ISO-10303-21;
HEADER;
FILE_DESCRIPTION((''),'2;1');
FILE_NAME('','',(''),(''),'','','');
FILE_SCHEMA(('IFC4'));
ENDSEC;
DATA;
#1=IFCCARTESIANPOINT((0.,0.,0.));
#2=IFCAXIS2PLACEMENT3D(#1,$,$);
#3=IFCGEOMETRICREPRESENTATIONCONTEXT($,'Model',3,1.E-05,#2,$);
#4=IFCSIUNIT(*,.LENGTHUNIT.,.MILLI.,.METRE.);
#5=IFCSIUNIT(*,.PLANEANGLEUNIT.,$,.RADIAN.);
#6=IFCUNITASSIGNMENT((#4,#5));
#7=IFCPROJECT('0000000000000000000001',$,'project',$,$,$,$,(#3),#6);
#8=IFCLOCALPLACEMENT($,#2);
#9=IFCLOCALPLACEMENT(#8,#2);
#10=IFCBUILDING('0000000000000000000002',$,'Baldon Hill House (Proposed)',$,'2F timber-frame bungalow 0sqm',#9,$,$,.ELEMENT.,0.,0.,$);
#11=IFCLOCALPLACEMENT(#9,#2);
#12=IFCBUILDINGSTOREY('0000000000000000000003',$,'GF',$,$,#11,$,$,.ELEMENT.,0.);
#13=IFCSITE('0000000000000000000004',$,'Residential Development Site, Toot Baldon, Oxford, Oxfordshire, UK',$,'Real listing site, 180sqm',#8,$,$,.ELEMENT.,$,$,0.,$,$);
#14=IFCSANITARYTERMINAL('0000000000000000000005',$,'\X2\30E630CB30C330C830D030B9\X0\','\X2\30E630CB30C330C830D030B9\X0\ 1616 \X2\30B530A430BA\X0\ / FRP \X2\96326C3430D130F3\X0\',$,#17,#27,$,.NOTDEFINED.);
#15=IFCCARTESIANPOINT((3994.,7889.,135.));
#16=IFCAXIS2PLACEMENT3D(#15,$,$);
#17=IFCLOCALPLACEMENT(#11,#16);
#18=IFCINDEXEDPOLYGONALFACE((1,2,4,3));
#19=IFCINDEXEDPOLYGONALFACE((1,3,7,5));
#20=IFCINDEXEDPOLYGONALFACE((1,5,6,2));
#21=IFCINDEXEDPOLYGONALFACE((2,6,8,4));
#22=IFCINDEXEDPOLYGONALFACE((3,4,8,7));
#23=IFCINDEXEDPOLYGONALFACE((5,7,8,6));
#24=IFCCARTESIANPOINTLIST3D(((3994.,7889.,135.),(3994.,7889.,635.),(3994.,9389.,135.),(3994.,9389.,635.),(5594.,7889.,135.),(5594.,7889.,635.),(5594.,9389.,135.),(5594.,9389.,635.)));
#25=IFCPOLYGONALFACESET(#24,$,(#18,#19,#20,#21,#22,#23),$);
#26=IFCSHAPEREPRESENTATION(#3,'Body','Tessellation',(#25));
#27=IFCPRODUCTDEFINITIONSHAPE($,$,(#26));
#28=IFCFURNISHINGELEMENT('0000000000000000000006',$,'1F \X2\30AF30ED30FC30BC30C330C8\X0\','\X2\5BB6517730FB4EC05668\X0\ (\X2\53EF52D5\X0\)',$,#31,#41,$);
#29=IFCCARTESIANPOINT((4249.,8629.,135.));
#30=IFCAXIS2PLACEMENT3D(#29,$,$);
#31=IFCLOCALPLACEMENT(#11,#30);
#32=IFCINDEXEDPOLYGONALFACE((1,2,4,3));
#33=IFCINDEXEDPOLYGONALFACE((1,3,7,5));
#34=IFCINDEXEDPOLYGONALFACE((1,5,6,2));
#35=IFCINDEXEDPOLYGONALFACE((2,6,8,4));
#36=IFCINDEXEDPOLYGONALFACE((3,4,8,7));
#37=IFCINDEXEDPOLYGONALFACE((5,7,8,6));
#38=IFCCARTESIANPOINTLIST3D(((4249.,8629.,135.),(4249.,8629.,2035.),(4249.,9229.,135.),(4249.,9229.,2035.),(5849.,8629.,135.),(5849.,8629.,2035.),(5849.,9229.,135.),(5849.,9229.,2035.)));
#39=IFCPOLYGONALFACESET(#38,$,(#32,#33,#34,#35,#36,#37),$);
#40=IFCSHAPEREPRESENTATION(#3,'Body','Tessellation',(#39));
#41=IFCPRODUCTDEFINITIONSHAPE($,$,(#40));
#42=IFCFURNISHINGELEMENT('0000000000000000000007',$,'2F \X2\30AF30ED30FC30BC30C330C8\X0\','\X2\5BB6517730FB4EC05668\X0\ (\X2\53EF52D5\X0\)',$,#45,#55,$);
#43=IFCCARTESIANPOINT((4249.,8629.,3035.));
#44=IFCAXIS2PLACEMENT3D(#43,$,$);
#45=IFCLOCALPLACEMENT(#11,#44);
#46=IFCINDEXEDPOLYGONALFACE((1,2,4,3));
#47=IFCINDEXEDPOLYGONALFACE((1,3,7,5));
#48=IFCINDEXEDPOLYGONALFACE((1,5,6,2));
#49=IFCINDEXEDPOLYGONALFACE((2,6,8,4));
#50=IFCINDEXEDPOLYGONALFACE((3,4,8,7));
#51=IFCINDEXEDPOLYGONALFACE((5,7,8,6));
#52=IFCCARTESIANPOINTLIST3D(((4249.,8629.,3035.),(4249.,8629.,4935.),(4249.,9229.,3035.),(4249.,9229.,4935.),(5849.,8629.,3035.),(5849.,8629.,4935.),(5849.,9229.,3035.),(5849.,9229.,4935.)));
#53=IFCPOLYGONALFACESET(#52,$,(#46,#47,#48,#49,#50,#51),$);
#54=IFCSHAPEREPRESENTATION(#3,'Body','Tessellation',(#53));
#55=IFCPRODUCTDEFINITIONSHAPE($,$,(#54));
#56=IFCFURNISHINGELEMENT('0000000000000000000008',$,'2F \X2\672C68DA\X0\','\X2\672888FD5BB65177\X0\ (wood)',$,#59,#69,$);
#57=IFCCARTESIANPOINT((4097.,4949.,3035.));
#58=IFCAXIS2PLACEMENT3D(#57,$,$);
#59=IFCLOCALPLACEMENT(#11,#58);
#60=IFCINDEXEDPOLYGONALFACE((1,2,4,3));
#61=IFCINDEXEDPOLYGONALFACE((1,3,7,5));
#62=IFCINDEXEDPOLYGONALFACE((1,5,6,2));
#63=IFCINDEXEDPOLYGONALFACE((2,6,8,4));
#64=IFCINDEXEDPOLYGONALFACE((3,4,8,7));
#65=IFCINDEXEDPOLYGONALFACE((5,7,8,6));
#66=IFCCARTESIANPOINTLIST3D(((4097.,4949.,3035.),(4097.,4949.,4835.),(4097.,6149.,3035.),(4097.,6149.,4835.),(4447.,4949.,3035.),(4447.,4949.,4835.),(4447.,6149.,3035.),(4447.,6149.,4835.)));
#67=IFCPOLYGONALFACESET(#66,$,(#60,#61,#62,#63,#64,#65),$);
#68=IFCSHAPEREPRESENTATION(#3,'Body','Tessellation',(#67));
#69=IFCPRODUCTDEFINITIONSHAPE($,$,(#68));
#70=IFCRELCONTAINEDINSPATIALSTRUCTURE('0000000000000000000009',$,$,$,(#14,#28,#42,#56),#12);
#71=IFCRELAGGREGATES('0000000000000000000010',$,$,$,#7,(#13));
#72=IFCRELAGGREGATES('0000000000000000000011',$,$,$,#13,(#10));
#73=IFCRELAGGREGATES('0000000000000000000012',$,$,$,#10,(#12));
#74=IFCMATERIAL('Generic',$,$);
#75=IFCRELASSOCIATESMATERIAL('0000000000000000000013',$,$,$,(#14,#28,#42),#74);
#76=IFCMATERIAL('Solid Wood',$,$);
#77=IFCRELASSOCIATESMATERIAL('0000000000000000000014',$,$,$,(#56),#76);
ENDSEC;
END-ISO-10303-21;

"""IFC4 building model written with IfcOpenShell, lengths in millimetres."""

from ifc_helpers import new_model, si_unit, frame, frame_2d, origin, place, context, project, spatial, rectangle, extrude, material, element, save


model = new_model("IFC4")

# Units and contexts
model_context = context("Model", 3, precision=1e-05, world=origin())
ifc_project = project(units=[si_unit("LENGTHUNIT", "METRE", prefix="MILLI"), si_unit("PLANEANGLEUNIT", "RADIAN")], contexts=[model_context])

# Site, building, storey
site_placement = place(None, origin())
site = spatial("IfcSite", under=ifc_project, at=site_placement, Name="Residential Development Site, Toot Baldon, Oxford, Oxfordshire, UK", ObjectType="Real listing site, 180sqm", CompositionType="ELEMENT", RefElevation=0.0)
building_placement = place(site_placement, origin())
building = spatial("IfcBuilding", under=site, at=building_placement, Name="Baldon Hill House (Proposed)", ObjectType="2F timber-frame bungalow 0sqm", CompositionType="ELEMENT", ElevationOfRefHeight=0.0, ElevationOfTerrain=0.0)
storey_placement = place(building_placement, origin())
storey = spatial("IfcBuildingStorey", under=building, at=storey_placement, Name="GF", CompositionType="ELEMENT", Elevation=0.0)

# Shared definitions
ifc_material_1 = material(Name="Solid Wood")

# Shared definitions
ifc_material_2 = material(Name="Generic")

# Sanitary terminal
sanitary_terminal_placement = place(storey_placement, frame((3994.0, 7889.0, 135.0)))
element("IfcSanitaryTerminal", 1, at=sanitary_terminal_placement, inside=storey, material=ifc_material_2, Name="ユニットバス", Description="ユニットバス 1616 サイズ / FRP 防水パン", PredefinedType="NOTDEFINED", context=model_context, shape_type="SweptSolid", body=[
    extrude(rectangle(XDim=1600.0, YDim=1500.0, at=frame_2d((800.0, 750.0))), frame((3994.0, 7889.0, 135.0)), (0.0, 0.0, 1.0), 500.0),
])

# Furnishing elements
furnishing_1_placement = place(storey_placement, frame((4249.0, 8629.0, 135.0)))
element("IfcFurnishingElement", 2, at=furnishing_1_placement, inside=storey, material=ifc_material_2, Name="1F クローゼット", Description="家具・什器 (可動)", context=model_context, shape_type="SweptSolid", body=[
    extrude(rectangle(XDim=1600.0, YDim=600.0, at=frame_2d((800.0, 300.0))), frame((4249.0, 8629.0, 135.0)), (0.0, 0.0, 1.0), 1900.0),
])
furnishing_2_placement = place(storey_placement, frame((4249.0, 8629.0, 3035.0)))
element("IfcFurnishingElement", 3, at=furnishing_2_placement, inside=storey, material=ifc_material_2, Name="2F クローゼット", Description="家具・什器 (可動)", context=model_context, shape_type="SweptSolid", body=[
    extrude(rectangle(XDim=1600.0, YDim=600.0, at=frame_2d((800.0, 300.0))), frame((4249.0, 8629.0, 3035.0)), (0.0, 0.0, 1.0), 1900.0),
])
furnishing_3_placement = place(storey_placement, frame((4097.0, 4949.0, 3035.0)))
element("IfcFurnishingElement", 4, at=furnishing_3_placement, inside=storey, material=ifc_material_1, Name="2F 本棚", Description="木製家具 (wood)", context=model_context, shape_type="SweptSolid", body=[
    extrude(rectangle(XDim=350.0, YDim=1200.0, at=frame_2d((175.0, 600.0))), frame((4097.0, 4949.0, 3035.0)), (0.0, 0.0, 1.0), 1800.0),
])

save(model, "model.ifc")
